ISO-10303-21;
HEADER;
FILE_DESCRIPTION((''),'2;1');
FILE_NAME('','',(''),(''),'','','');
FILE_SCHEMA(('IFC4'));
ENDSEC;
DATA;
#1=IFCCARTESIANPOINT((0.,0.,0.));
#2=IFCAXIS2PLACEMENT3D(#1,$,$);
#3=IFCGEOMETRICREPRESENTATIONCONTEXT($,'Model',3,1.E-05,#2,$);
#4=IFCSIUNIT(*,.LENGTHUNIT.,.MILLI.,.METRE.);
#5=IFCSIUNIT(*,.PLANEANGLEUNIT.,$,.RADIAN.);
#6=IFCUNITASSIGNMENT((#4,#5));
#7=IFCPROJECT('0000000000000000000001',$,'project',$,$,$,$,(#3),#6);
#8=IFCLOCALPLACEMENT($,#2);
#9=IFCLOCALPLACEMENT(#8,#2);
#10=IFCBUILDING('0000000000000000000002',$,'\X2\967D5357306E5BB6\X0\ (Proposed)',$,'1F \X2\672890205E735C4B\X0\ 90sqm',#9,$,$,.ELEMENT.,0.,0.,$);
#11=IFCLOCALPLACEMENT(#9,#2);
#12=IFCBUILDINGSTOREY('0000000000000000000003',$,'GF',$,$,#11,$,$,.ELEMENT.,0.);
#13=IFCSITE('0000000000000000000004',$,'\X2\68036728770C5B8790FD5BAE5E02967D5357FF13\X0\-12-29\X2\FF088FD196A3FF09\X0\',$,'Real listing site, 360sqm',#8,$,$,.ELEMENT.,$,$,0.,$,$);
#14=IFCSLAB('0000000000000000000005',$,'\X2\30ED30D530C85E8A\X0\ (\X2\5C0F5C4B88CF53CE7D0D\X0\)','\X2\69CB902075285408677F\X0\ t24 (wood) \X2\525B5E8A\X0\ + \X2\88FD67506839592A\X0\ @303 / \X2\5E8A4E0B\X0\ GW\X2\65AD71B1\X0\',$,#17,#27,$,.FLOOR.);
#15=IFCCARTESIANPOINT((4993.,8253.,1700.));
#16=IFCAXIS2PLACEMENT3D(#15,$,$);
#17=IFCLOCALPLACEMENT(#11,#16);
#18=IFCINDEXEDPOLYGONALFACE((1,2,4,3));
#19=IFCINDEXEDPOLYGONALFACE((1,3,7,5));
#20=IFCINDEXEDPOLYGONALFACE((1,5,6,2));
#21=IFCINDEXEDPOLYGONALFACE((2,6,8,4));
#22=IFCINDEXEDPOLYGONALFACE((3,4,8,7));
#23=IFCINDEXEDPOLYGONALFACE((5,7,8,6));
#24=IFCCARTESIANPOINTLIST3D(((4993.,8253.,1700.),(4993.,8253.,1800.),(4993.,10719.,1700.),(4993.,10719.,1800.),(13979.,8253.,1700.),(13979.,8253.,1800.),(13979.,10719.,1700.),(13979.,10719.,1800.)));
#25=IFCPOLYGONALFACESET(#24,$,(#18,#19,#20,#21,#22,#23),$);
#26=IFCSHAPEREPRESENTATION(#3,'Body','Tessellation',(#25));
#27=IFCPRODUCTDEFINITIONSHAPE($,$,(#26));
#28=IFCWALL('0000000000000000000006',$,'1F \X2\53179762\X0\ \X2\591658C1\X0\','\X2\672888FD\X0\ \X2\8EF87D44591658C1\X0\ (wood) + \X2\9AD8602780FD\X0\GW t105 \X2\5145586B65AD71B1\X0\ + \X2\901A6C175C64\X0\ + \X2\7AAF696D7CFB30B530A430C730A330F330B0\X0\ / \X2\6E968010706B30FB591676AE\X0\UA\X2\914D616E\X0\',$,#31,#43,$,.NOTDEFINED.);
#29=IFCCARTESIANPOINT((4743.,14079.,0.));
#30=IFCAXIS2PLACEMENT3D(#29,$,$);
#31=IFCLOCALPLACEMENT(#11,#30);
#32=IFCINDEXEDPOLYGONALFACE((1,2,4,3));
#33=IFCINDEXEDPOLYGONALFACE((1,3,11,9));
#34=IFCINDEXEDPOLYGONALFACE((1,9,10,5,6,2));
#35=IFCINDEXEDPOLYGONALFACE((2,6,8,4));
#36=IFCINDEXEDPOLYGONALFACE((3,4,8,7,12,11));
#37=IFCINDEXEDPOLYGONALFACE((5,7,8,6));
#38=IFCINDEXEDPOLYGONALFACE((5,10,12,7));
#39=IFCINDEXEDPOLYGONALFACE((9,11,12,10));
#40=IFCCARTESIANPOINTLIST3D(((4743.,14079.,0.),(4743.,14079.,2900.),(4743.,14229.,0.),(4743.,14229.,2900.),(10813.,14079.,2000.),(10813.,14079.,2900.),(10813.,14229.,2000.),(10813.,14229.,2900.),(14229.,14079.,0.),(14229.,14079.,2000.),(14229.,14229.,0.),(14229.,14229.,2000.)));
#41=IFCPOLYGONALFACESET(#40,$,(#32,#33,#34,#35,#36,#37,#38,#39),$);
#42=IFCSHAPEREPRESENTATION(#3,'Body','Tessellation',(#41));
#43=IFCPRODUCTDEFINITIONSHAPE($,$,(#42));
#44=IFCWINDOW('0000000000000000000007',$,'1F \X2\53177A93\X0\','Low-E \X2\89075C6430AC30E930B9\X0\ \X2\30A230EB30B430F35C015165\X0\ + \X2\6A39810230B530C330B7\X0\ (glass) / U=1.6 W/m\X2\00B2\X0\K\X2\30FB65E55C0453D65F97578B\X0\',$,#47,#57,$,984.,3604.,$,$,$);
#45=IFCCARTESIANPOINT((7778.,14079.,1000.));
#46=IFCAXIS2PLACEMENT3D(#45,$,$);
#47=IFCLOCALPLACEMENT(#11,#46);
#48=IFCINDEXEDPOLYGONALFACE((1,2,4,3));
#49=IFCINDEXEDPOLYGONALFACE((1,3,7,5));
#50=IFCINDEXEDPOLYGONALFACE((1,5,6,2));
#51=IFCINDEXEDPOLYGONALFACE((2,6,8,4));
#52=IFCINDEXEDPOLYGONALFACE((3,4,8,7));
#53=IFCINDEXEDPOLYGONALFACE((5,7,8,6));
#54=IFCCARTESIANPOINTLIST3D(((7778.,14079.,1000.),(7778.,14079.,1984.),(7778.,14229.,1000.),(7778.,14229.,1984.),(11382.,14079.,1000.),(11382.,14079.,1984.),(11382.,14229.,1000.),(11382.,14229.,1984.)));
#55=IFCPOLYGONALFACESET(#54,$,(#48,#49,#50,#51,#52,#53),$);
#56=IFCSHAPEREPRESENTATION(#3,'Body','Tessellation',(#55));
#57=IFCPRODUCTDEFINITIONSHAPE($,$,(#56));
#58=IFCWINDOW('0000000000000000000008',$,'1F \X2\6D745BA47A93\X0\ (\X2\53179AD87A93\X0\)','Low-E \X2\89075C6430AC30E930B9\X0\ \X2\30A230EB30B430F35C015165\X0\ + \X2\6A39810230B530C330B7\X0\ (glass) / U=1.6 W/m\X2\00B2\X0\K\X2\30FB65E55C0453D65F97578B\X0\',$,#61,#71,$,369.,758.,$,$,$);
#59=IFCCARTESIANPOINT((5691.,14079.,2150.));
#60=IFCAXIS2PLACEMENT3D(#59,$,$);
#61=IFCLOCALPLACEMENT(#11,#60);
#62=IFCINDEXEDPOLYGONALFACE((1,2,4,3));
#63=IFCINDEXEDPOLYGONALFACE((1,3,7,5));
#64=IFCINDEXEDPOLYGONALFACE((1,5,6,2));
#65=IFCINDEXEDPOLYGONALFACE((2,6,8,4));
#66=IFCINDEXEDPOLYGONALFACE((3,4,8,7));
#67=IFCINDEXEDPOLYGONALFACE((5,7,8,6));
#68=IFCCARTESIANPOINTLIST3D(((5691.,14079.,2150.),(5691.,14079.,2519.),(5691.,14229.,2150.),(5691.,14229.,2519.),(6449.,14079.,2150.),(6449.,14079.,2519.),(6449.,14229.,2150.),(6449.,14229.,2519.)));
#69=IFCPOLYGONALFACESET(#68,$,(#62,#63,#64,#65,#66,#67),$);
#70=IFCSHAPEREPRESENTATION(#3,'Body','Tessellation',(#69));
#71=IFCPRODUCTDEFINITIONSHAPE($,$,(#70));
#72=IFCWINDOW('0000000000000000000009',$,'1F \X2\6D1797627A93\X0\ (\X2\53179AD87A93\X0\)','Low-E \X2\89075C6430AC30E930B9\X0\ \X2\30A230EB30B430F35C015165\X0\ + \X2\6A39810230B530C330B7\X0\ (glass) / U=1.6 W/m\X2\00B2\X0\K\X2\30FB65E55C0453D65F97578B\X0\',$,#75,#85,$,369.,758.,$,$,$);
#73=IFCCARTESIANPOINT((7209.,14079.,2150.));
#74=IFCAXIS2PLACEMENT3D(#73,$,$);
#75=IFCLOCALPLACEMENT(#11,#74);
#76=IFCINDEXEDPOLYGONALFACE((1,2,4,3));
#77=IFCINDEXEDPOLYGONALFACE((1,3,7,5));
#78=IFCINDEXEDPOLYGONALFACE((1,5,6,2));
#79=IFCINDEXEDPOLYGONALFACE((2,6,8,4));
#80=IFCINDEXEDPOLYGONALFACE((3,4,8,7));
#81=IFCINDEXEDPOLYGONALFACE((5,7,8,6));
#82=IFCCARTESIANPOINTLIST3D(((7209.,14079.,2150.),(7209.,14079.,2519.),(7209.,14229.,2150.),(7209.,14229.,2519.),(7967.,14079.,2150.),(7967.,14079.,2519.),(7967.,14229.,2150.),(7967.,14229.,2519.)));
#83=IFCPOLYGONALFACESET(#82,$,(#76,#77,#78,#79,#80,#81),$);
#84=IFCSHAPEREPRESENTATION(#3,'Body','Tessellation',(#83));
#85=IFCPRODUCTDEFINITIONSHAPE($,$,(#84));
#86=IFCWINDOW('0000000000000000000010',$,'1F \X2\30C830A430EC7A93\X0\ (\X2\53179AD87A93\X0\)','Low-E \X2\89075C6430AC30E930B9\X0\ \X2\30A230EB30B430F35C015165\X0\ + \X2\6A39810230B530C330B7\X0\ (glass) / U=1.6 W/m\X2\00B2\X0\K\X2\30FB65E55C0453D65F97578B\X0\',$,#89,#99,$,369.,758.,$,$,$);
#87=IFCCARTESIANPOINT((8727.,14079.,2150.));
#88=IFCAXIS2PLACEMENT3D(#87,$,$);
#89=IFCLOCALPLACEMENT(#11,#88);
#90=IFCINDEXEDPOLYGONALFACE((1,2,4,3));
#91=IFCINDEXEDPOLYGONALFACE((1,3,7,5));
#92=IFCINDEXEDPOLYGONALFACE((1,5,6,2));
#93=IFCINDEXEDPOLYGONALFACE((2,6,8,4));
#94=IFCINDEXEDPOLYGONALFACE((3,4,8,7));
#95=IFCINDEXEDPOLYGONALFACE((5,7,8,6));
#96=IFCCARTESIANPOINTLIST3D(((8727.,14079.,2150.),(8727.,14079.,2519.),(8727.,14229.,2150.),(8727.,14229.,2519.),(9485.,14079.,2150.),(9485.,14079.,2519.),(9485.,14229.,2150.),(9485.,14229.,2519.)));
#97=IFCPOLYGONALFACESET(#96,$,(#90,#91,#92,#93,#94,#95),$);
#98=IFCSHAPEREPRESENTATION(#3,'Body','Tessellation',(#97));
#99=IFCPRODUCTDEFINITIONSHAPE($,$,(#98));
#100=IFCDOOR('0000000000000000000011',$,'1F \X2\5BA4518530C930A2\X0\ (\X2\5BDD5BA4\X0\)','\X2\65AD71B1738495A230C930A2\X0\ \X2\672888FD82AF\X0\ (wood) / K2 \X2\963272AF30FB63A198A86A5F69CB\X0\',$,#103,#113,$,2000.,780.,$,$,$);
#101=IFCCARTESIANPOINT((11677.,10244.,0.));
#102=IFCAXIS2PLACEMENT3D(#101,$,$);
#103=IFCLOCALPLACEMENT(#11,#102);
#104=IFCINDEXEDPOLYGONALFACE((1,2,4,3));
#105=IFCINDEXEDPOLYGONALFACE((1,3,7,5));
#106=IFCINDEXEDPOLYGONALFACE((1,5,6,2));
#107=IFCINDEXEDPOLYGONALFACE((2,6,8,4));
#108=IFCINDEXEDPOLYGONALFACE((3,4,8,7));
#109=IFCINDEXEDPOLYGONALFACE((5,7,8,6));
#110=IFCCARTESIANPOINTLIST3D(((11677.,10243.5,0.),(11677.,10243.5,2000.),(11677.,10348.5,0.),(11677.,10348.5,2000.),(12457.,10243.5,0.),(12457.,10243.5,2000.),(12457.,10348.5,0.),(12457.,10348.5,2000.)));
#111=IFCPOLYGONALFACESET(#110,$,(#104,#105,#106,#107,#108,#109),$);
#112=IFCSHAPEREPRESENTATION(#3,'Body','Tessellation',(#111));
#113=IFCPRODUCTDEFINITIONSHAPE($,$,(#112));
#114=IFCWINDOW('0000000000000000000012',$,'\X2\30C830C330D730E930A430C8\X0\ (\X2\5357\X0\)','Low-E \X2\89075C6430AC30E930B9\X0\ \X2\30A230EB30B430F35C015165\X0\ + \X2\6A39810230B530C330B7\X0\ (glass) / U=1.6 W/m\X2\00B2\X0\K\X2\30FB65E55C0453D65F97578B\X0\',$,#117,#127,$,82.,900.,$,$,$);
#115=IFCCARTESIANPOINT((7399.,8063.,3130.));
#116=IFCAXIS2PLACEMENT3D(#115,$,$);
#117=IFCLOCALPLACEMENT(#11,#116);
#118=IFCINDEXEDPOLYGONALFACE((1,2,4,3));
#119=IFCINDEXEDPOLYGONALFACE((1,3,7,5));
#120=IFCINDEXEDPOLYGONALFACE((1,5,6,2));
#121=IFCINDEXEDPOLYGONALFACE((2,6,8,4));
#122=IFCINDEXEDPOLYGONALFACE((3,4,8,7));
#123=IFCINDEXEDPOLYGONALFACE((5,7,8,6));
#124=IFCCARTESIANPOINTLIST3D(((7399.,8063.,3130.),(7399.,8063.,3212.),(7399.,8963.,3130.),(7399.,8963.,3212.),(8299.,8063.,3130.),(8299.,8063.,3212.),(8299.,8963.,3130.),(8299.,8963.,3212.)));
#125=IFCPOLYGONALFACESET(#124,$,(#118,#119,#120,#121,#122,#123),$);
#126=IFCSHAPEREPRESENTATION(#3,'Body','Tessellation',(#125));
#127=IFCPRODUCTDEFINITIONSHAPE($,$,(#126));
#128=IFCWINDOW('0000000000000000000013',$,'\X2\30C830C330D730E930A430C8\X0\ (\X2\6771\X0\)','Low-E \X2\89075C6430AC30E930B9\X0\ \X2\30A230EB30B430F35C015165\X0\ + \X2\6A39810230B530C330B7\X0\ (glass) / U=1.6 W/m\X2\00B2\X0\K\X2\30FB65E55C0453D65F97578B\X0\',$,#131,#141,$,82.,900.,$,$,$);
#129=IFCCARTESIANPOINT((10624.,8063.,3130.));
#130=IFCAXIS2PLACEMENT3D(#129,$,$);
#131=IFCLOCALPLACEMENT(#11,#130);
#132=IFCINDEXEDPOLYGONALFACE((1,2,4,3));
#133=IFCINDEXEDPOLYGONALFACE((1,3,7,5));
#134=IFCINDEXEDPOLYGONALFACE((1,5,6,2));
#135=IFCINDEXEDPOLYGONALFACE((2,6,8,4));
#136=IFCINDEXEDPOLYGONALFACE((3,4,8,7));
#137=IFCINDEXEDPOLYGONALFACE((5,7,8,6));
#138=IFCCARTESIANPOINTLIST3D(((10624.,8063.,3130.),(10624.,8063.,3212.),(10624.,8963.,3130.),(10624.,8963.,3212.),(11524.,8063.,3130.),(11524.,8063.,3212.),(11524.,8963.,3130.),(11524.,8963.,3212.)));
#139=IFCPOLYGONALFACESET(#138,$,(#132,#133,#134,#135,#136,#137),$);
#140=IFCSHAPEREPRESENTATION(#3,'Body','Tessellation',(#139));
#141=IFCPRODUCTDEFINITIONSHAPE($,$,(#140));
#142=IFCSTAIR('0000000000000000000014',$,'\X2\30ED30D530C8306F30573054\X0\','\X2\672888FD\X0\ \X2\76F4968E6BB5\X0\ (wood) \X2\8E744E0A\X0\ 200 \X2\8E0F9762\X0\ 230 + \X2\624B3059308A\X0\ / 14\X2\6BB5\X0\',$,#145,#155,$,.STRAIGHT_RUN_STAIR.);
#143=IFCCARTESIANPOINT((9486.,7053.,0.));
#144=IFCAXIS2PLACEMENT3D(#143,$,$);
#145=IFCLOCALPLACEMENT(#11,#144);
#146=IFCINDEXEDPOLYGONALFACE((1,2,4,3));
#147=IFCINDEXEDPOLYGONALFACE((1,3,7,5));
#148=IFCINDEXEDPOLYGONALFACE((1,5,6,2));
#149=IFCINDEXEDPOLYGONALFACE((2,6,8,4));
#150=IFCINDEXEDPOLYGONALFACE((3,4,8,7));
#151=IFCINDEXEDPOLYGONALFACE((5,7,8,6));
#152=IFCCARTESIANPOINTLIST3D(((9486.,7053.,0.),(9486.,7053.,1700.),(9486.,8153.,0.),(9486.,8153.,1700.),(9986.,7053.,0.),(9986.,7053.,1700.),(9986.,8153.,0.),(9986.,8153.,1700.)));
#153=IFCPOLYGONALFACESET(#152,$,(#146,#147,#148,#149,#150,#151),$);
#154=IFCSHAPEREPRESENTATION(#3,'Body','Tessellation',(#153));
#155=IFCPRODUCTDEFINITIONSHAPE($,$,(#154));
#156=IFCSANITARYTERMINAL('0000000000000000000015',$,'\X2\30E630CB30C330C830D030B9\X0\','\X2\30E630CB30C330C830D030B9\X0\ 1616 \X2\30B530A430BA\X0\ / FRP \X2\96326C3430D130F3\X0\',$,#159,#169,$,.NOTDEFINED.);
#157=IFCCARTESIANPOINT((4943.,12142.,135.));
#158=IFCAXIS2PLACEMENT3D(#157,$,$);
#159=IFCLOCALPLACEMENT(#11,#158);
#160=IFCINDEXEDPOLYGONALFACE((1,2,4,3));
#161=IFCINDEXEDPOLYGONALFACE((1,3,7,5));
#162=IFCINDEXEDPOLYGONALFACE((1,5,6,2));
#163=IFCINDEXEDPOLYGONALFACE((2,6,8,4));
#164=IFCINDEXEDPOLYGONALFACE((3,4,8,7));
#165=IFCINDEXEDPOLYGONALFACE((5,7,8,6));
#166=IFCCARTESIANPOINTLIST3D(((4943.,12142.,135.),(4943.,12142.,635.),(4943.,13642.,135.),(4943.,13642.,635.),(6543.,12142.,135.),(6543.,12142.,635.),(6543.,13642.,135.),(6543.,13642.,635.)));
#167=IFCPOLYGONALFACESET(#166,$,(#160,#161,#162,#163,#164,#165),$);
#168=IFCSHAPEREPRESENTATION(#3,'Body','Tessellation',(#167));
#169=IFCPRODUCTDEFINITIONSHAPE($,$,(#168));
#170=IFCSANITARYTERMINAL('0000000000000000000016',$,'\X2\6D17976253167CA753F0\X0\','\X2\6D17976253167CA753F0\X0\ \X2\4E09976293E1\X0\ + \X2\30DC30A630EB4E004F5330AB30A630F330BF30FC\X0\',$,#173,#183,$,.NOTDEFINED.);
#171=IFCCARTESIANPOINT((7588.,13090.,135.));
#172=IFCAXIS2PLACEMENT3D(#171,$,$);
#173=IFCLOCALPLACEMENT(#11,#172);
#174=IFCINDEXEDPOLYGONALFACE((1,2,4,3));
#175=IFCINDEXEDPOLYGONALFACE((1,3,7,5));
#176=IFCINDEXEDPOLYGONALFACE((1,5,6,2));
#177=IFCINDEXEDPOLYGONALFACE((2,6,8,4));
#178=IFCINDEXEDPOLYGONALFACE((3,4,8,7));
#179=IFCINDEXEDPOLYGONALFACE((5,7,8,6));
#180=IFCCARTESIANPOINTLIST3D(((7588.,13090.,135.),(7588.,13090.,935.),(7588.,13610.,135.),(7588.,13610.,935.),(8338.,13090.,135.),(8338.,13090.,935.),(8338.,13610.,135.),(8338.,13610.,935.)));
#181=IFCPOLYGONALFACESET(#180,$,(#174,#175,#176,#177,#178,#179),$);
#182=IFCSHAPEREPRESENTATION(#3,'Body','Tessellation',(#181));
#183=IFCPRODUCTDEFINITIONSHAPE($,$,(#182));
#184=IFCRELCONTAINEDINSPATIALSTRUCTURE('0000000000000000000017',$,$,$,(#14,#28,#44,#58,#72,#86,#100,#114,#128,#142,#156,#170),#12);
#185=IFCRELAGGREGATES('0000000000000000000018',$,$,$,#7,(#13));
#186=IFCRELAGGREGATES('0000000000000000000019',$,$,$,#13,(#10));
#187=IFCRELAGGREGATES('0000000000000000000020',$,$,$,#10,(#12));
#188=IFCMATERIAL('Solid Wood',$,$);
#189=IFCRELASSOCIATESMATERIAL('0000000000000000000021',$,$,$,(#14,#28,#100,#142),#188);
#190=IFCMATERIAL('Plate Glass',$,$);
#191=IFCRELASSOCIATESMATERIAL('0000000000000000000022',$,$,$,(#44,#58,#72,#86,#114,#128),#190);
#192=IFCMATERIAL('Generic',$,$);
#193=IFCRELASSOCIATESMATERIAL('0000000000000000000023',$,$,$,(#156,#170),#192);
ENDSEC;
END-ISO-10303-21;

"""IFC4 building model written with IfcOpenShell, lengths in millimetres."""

from ifc_helpers import new_model, si_unit, frame, frame_2d, origin, place, context, project, spatial, rectangle, extrude, material, element, fill, save


model = new_model("IFC4")

# Units and contexts
model_context = context("Model", 3, precision=1e-05, world=origin())
ifc_project = project(units=[si_unit("LENGTHUNIT", "METRE", prefix="MILLI"), si_unit("PLANEANGLEUNIT", "RADIAN")], contexts=[model_context])

# Site, building, storey
site_placement = place(None, origin())
site = spatial("IfcSite", under=ifc_project, at=site_placement, Name="栃木県宇都宮市陽南３-12-29（近隣）", ObjectType="Real listing site, 360sqm", CompositionType="ELEMENT", RefElevation=0.0)
building_placement = place(site_placement, origin())
building = spatial("IfcBuilding", under=site, at=building_placement, Name="陽南の家 (Proposed)", ObjectType="1F 木造平屋 90sqm", CompositionType="ELEMENT", ElevationOfRefHeight=0.0, ElevationOfTerrain=0.0)
storey_placement = place(building_placement, origin())
storey = spatial("IfcBuildingStorey", under=building, at=storey_placement, Name="GF", CompositionType="ELEMENT", Elevation=0.0)

# Slab
ifc_material_1 = material(Name="Solid Wood")
slab_placement = place(storey_placement, frame((4993.0, 8253.0, 1700.0)))
element("IfcSlab", 1, at=slab_placement, inside=storey, material=ifc_material_1, Name="ロフト床 (小屋裏収納)", Description="構造用合板 t24 (wood) 剛床 + 製材根太 @303 / 床下 GW断熱", PredefinedType="FLOOR", context=model_context, shape_type="SweptSolid", body=[
    extrude(rectangle(XDim=8986.0, YDim=2466.0, at=frame_2d((4493.0, 1233.0))), frame((4993.0, 8253.0, 1700.0)), (0.0, 0.0, 1.0), 100.0),
])

# Wall, openings, windows
wall_1_placement = place(storey_placement, frame((4743.0, 14079.0, 0.0)))
wall_1 = element("IfcWall", 2, at=wall_1_placement, inside=storey, material=ifc_material_1, Name="1F 北面 外壁", Description="木製 軸組外壁 (wood) + 高性能GW t105 充填断熱 + 通気層 + 窯業系サイディング / 準耐火・外皮UA配慮", PredefinedType="NOTDEFINED", context=model_context, shape_type="SweptSolid", body=[
    extrude(rectangle(XDim=9486.0, YDim=150.0, at=frame_2d((4743.0, 75.0))), frame((4743.0, 14079.0, 0.0)), (0.0, 0.0, 1.0), 2900.0),
])
opening_1_placement = place(storey_placement, frame((7778.0, 14079.0, 1000.0)))
opening_1 = element("IfcOpeningElement", 3, at=opening_1_placement, cuts=wall_1, PredefinedType="NOTDEFINED", context=model_context, shape_type="SweptSolid", body=[
    extrude(rectangle(XDim=3604.0, YDim=150.0, at=frame_2d((1802.0, 75.0))), frame((7778.0, 14079.0, 1000.0)), (0.0, 0.0, 1.0), 984.0),
])
opening_2_placement = place(storey_placement, frame((5691.0, 14079.0, 2150.0)))
opening_2 = element("IfcOpeningElement", 4, at=opening_2_placement, cuts=wall_1, PredefinedType="NOTDEFINED", context=model_context, shape_type="SweptSolid", body=[
    extrude(rectangle(XDim=758.0, YDim=150.0, at=frame_2d((379.0, 75.0))), frame((5691.0, 14079.0, 2150.0)), (0.0, 0.0, 1.0), 369.0),
])
opening_3_placement = place(storey_placement, frame((7209.0, 14079.0, 2150.0)))
opening_3 = element("IfcOpeningElement", 5, at=opening_3_placement, cuts=wall_1, PredefinedType="NOTDEFINED", context=model_context, shape_type="SweptSolid", body=[
    extrude(rectangle(XDim=758.0, YDim=150.0, at=frame_2d((379.0, 75.0))), frame((7209.0, 14079.0, 2150.0)), (0.0, 0.0, 1.0), 369.0),
])
opening_4_placement = place(storey_placement, frame((8727.0, 14079.0, 2150.0)))
opening_4 = element("IfcOpeningElement", 6, at=opening_4_placement, cuts=wall_1, PredefinedType="NOTDEFINED", context=model_context, shape_type="SweptSolid", body=[
    extrude(rectangle(XDim=758.0, YDim=150.0, at=frame_2d((379.0, 75.0))), frame((8727.0, 14079.0, 2150.0)), (0.0, 0.0, 1.0), 369.0),
])
ifc_material_2 = material(Name="Plate Glass")
window_1_placement = place(storey_placement, frame((7778.0, 14079.0, 1000.0)))
window_1 = element("IfcWindow", 7, at=window_1_placement, inside=storey, material=ifc_material_2, Name="1F 北窓", Description="Low-E 複層ガラス アルゴン封入 + 樹脂サッシ (glass) / U=1.6 W/m²K・日射取得型", OverallHeight=984.0, OverallWidth=3604.0, context=model_context, shape_type="SweptSolid", body=[
    extrude(rectangle(XDim=3604.0, YDim=150.0, at=frame_2d((1802.0, 75.0))), frame((7778.0, 14079.0, 1000.0)), (0.0, 0.0, 1.0), 984.0),
])
fill(opening_1, window_1)
window_2_placement = place(storey_placement, frame((5691.0, 14079.0, 2150.0)))
window_2 = element("IfcWindow", 8, at=window_2_placement, inside=storey, material=ifc_material_2, Name="1F 浴室窓 (北高窓)", Description="Low-E 複層ガラス アルゴン封入 + 樹脂サッシ (glass) / U=1.6 W/m²K・日射取得型", OverallHeight=369.0, OverallWidth=758.0, context=model_context, shape_type="SweptSolid", body=[
    extrude(rectangle(XDim=758.0, YDim=150.0, at=frame_2d((379.0, 75.0))), frame((5691.0, 14079.0, 2150.0)), (0.0, 0.0, 1.0), 369.0),
])
fill(opening_2, window_2)
window_3_placement = place(storey_placement, frame((7209.0, 14079.0, 2150.0)))
window_3 = element("IfcWindow", 9, at=window_3_placement, inside=storey, material=ifc_material_2, Name="1F 洗面窓 (北高窓)", Description="Low-E 複層ガラス アルゴン封入 + 樹脂サッシ (glass) / U=1.6 W/m²K・日射取得型", OverallHeight=369.0, OverallWidth=758.0, context=model_context, shape_type="SweptSolid", body=[
    extrude(rectangle(XDim=758.0, YDim=150.0, at=frame_2d((379.0, 75.0))), frame((7209.0, 14079.0, 2150.0)), (0.0, 0.0, 1.0), 369.0),
])
fill(opening_3, window_3)
window_4_placement = place(storey_placement, frame((8727.0, 14079.0, 2150.0)))
window_4 = element("IfcWindow", 10, at=window_4_placement, inside=storey, material=ifc_material_2, Name="1F トイレ窓 (北高窓)", Description="Low-E 複層ガラス アルゴン封入 + 樹脂サッシ (glass) / U=1.6 W/m²K・日射取得型", OverallHeight=369.0, OverallWidth=758.0, context=model_context, shape_type="SweptSolid", body=[
    extrude(rectangle(XDim=758.0, YDim=150.0, at=frame_2d((379.0, 75.0))), frame((8727.0, 14079.0, 2150.0)), (0.0, 0.0, 1.0), 369.0),
])
fill(opening_4, window_4)

# Door
door_1_placement = place(storey_placement, frame((11677.0, 10244.0, 0.0)))
element("IfcDoor", 11, at=door_1_placement, inside=storey, material=ifc_material_1, Name="1F 室内ドア (寝室)", Description="断熱玄関ドア 木製芯 (wood) / K2 防犯・採風機構", OverallHeight=2000.0, OverallWidth=780.0, context=model_context, shape_type="SweptSolid", body=[
    extrude(rectangle(XDim=780.0, YDim=105.0, at=frame_2d((390.0, 52.0))), frame((11677.0, 10244.0, 0.0)), (0.0, 0.0, 1.0), 2000.0),
])

# Windows
window_5_placement = place(storey_placement, frame((7399.0, 8063.0, 3130.0)))
element("IfcWindow", 12, at=window_5_placement, inside=storey, material=ifc_material_2, Name="トップライト (南)", Description="Low-E 複層ガラス アルゴン封入 + 樹脂サッシ (glass) / U=1.6 W/m²K・日射取得型", OverallHeight=82.0, OverallWidth=900.0, context=model_context, shape_type="SweptSolid", body=[
    extrude(rectangle(XDim=900.0, YDim=900.0, at=frame_2d((450.0, 450.0))), frame((7399.0, 8063.0, 3130.0)), (0.0, 0.0, 1.0), 82.0),
])
window_6_placement = place(storey_placement, frame((10624.0, 8063.0, 3130.0)))
element("IfcWindow", 13, at=window_6_placement, inside=storey, material=ifc_material_2, Name="トップライト (東)", Description="Low-E 複層ガラス アルゴン封入 + 樹脂サッシ (glass) / U=1.6 W/m²K・日射取得型", OverallHeight=82.0, OverallWidth=900.0, context=model_context, shape_type="SweptSolid", body=[
    extrude(rectangle(XDim=900.0, YDim=900.0, at=frame_2d((450.0, 450.0))), frame((10624.0, 8063.0, 3130.0)), (0.0, 0.0, 1.0), 82.0),
])

# Stair
stair_placement = place(storey_placement, frame((9486.0, 7053.0, 0.0)))
element("IfcStair", 14, at=stair_placement, inside=storey, material=ifc_material_1, Name="ロフトはしご", Description="木製 直階段 (wood) 蹴上 200 踏面 230 + 手すり / 14段", PredefinedType="STRAIGHT_RUN_STAIR", context=model_context, shape_type="SweptSolid", body=[
    extrude(rectangle(XDim=500.0, YDim=1100.0, at=frame_2d((250.0, 550.0))), frame((9486.0, 7053.0, 0.0)), (0.0, 0.0, 1.0), 1700.0),
])

# Sanitary terminals
ifc_material_3 = material(Name="Generic")
sanitary_terminal_1_placement = place(storey_placement, frame((4943.0, 12142.0, 135.0)))
element("IfcSanitaryTerminal", 15, at=sanitary_terminal_1_placement, inside=storey, material=ifc_material_3, Name="ユニットバス", Description="ユニットバス 1616 サイズ / FRP 防水パン", PredefinedType="NOTDEFINED", context=model_context, shape_type="SweptSolid", body=[
    extrude(rectangle(XDim=1600.0, YDim=1500.0, at=frame_2d((800.0, 750.0))), frame((4943.0, 12142.0, 135.0)), (0.0, 0.0, 1.0), 500.0),
])
sanitary_terminal_2_placement = place(storey_placement, frame((7588.0, 13090.0, 135.0)))
element("IfcSanitaryTerminal", 16, at=sanitary_terminal_2_placement, inside=storey, material=ifc_material_3, Name="洗面化粧台", Description="洗面化粧台 三面鏡 + ボウル一体カウンター", PredefinedType="NOTDEFINED", context=model_context, shape_type="SweptSolid", body=[
    extrude(rectangle(XDim=750.0, YDim=520.0, at=frame_2d((375.0, 260.0))), frame((7588.0, 13090.0, 135.0)), (0.0, 0.0, 1.0), 800.0),
])

save(model, "model.ifc")
